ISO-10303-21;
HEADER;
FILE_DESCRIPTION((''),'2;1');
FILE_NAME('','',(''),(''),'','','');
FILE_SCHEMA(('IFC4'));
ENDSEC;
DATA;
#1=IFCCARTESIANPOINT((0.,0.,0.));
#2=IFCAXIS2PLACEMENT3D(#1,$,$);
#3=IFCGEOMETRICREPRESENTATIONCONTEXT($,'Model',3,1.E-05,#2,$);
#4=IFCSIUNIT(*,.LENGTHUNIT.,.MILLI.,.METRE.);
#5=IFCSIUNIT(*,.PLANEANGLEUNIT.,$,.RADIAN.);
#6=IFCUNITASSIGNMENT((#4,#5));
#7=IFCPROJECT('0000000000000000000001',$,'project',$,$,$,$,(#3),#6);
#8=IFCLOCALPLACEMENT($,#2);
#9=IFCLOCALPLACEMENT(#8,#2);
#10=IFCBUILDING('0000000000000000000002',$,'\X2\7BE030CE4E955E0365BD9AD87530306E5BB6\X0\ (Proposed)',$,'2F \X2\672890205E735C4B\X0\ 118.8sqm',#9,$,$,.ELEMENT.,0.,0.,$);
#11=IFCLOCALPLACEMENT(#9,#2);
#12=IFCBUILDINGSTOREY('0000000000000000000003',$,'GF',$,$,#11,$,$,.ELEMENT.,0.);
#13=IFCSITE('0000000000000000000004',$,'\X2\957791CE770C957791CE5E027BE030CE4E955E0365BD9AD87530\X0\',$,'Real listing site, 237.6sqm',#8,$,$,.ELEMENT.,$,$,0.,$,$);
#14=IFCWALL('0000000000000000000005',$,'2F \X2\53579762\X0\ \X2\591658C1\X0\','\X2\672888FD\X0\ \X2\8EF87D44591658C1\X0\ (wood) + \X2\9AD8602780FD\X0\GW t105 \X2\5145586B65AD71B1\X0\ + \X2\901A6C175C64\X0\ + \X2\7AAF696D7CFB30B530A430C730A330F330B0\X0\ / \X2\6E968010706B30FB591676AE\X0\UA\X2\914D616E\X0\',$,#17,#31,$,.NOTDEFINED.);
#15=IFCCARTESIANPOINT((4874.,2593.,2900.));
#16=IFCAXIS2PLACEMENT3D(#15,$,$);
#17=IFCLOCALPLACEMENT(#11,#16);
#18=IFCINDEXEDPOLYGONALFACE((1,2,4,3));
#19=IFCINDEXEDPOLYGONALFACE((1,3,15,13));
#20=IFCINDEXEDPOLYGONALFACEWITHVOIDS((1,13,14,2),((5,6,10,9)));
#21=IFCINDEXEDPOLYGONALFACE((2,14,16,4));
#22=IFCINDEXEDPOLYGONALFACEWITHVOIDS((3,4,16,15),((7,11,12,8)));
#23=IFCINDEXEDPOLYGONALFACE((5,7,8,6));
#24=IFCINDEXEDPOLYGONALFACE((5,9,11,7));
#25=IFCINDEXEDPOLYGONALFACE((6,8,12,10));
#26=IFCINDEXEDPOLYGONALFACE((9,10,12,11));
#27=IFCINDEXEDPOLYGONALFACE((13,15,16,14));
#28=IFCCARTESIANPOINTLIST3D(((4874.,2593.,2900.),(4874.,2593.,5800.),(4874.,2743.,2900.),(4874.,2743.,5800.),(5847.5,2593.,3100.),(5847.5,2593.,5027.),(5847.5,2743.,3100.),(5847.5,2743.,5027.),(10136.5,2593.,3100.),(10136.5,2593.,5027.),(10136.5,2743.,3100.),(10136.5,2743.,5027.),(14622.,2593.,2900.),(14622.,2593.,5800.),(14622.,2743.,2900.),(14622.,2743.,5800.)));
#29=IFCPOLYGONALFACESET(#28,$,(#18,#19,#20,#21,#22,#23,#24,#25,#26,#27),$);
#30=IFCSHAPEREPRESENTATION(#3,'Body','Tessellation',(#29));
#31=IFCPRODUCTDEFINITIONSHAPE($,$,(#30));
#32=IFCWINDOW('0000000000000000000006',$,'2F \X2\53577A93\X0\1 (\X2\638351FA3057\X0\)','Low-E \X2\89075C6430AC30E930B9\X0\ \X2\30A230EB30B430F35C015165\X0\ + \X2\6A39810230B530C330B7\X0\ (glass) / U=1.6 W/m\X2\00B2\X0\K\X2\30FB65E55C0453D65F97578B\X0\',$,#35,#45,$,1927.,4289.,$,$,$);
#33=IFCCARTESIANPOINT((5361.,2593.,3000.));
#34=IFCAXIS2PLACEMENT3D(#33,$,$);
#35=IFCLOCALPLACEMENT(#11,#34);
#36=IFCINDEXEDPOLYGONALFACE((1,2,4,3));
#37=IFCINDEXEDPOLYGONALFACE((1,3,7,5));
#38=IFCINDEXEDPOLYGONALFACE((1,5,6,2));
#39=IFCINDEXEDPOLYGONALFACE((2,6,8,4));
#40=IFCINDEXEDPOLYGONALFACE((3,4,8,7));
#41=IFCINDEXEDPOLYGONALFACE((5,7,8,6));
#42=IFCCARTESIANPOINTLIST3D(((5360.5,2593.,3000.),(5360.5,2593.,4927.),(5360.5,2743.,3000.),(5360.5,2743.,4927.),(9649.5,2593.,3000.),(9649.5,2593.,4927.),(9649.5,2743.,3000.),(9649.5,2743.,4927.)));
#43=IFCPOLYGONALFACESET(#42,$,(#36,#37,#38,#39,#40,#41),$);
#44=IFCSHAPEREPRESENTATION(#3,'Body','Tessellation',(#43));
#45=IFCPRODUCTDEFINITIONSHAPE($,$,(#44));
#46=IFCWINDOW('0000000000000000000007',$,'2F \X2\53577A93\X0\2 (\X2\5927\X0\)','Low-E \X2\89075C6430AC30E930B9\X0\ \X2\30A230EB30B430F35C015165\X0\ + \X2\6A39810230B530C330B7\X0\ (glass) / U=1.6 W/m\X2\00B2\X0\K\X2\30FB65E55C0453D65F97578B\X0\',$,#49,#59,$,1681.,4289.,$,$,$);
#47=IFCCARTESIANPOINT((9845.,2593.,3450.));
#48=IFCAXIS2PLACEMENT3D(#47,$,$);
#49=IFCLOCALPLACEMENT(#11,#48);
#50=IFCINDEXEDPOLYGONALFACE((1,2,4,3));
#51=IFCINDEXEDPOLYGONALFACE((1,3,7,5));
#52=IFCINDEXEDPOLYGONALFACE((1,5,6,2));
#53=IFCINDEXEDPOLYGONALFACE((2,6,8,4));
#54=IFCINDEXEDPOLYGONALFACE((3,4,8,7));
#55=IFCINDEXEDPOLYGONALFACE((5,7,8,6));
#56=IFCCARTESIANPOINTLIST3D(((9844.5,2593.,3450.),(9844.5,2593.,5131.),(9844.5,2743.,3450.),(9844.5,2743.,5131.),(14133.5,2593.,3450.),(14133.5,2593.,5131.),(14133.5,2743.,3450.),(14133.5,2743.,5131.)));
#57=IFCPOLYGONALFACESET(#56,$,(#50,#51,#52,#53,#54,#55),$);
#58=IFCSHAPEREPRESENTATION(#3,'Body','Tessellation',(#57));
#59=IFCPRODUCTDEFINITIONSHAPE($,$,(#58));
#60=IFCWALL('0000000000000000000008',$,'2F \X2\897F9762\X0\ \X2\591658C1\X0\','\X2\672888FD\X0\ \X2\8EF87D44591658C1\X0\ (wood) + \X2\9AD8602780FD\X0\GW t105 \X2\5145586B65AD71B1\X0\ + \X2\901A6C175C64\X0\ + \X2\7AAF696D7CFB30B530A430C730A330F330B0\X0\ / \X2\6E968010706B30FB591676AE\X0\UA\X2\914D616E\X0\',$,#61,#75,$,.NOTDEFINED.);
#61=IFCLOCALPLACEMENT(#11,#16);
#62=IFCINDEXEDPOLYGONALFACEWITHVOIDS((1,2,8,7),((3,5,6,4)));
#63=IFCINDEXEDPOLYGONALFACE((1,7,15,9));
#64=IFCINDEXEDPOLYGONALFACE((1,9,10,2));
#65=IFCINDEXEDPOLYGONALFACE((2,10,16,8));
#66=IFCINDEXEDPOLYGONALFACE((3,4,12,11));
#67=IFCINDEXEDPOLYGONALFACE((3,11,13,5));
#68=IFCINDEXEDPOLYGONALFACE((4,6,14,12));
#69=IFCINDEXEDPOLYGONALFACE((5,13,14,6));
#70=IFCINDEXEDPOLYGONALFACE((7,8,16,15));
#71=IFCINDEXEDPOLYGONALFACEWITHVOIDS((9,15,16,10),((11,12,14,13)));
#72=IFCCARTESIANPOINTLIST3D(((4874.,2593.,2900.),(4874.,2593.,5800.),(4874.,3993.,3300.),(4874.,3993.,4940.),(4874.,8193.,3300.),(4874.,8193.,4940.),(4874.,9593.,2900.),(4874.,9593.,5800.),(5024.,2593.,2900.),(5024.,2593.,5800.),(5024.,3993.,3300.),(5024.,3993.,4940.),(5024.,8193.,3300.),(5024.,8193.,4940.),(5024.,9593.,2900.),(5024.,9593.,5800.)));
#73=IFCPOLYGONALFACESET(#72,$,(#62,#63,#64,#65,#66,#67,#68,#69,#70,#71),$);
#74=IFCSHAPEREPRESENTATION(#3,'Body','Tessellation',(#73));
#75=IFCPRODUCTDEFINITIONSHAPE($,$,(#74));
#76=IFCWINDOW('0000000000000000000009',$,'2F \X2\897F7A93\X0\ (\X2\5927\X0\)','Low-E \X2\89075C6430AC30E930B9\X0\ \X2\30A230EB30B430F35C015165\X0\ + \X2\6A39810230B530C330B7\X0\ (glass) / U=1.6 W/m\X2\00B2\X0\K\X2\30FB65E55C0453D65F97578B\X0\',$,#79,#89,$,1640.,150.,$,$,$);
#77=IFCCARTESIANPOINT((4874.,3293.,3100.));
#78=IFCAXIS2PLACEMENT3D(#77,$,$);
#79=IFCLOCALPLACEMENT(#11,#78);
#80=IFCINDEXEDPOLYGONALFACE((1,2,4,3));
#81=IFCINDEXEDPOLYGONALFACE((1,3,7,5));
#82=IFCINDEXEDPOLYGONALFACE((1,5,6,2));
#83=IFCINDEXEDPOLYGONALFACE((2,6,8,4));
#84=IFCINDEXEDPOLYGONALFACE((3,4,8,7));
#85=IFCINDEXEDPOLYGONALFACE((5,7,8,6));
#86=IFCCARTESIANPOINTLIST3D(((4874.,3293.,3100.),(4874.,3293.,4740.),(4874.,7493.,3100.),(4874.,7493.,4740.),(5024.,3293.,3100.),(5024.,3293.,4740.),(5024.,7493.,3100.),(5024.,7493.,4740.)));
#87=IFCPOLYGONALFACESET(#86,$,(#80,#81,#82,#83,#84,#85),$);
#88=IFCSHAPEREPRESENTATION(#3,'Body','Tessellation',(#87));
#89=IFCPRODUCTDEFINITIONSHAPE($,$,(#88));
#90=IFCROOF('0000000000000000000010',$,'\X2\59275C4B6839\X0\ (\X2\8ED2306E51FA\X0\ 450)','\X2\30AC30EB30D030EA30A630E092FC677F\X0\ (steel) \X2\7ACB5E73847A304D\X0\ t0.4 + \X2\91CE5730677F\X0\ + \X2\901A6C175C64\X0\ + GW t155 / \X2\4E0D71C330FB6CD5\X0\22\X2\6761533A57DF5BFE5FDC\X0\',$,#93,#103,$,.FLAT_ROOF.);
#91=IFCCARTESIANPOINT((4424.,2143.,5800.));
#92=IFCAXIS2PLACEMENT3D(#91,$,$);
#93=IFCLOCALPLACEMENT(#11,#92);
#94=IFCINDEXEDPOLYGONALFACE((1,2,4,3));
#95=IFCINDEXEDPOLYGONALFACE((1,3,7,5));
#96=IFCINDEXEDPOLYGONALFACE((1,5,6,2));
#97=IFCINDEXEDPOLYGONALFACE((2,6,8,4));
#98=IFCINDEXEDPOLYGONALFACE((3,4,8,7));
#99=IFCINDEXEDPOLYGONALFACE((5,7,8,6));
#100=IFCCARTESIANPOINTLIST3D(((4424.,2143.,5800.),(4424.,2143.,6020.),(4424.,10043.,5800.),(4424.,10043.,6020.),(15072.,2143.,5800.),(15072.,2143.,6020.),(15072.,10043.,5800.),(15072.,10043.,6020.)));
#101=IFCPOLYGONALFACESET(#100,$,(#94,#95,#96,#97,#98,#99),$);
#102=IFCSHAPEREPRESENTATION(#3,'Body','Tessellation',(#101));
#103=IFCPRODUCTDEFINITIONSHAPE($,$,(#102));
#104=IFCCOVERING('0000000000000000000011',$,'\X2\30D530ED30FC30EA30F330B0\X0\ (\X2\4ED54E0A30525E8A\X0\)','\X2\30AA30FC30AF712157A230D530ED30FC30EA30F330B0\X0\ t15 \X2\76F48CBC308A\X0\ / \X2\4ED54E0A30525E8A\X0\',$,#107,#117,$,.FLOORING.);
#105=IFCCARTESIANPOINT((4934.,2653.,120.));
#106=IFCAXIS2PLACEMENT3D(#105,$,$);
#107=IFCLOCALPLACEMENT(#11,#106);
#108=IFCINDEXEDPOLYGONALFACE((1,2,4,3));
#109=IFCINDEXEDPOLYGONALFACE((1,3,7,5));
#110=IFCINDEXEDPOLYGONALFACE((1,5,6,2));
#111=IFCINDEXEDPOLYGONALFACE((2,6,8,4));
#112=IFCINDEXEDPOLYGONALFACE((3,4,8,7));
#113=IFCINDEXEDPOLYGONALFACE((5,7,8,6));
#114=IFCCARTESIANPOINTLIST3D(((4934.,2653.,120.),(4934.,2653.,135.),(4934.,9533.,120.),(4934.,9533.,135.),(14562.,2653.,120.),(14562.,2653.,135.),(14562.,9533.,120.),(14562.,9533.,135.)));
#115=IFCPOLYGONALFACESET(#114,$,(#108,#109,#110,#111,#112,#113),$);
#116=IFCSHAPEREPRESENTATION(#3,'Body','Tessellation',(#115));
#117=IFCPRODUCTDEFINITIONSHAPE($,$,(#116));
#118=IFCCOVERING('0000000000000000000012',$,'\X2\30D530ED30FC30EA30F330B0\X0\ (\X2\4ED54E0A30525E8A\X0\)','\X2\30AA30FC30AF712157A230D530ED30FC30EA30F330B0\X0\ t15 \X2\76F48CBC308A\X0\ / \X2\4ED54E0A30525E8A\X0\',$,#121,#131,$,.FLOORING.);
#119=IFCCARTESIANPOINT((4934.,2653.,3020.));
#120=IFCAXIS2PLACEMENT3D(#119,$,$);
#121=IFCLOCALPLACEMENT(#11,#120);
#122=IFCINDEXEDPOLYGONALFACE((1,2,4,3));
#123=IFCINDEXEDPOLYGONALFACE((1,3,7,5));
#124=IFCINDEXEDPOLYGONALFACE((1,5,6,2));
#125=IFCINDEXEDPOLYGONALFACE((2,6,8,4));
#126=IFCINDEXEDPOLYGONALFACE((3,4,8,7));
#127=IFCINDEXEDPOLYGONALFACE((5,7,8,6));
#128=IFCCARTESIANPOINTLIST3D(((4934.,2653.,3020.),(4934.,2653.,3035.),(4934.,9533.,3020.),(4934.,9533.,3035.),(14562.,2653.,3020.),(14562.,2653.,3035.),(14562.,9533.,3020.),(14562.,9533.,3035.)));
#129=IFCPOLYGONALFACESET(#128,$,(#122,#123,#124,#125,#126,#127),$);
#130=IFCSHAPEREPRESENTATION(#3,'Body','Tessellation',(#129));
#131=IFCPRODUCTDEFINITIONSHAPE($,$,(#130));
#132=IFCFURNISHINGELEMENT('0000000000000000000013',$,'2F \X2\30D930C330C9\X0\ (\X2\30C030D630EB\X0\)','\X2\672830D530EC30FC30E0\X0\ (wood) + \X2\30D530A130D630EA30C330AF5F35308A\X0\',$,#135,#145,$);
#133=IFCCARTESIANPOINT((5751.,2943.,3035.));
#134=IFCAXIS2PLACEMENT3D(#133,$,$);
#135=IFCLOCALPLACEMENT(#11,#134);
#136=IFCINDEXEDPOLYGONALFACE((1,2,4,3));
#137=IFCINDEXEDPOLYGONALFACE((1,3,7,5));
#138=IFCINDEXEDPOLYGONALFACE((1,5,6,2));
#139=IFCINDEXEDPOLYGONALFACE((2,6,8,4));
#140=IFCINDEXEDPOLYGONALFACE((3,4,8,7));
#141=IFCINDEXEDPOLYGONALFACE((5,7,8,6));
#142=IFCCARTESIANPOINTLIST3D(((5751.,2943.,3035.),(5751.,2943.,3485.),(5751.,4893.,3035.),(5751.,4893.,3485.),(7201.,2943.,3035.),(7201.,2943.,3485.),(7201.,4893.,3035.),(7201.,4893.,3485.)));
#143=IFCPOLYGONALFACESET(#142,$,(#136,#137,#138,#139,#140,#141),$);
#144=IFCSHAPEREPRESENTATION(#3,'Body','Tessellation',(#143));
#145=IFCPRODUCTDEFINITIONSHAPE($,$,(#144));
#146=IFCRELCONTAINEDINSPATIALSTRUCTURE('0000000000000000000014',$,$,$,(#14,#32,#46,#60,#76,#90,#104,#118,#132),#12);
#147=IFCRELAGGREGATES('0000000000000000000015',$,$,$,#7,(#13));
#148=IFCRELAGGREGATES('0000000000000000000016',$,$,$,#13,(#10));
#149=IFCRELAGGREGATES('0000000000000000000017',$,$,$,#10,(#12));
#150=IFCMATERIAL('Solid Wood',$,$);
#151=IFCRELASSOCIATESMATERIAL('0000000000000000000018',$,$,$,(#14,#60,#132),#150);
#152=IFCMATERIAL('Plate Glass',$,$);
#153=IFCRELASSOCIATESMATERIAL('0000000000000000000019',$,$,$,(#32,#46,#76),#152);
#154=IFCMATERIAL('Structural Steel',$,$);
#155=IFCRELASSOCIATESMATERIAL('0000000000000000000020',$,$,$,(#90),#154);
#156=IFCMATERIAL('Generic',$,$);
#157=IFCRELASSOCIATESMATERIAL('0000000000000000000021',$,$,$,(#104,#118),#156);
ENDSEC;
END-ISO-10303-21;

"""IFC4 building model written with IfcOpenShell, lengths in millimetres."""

from ifc_helpers import new_model, si_unit, frame, frame_2d, origin, place, context, project, spatial, rectangle, extrude, material, element, fill, save


model = new_model("IFC4")

# Units and contexts
model_context = context("Model", 3, precision=1e-05, world=origin())
ifc_project = project(units=[si_unit("LENGTHUNIT", "METRE", prefix="MILLI"), si_unit("PLANEANGLEUNIT", "RADIAN")], contexts=[model_context])

# Site, building, storey
site_placement = place(None, origin())
site = spatial("IfcSite", under=ifc_project, at=site_placement, Name="長野県長野市篠ノ井布施高田", ObjectType="Real listing site, 237.6sqm", CompositionType="ELEMENT", RefElevation=0.0)
building_placement = place(site_placement, origin())
building = spatial("IfcBuilding", under=site, at=building_placement, Name="篠ノ井布施高田の家 (Proposed)", ObjectType="2F 木造平屋 118.8sqm", CompositionType="ELEMENT", ElevationOfRefHeight=0.0, ElevationOfTerrain=0.0)
storey_placement = place(building_placement, origin())
storey = spatial("IfcBuildingStorey", under=building, at=storey_placement, Name="GF", CompositionType="ELEMENT", Elevation=0.0)

# Shared definitions
ifc_material_1 = material(Name="Solid Wood")

# Shared definitions
ifc_material_2 = material(Name="Plate Glass")

# Wall, openings, windows
wall_1_placement = place(storey_placement, frame((4874.0, 2593.0, 2900.0)))
wall_1 = element("IfcWall", 1, at=wall_1_placement, inside=storey, material=ifc_material_1, Name="2F 南面 外壁", Description="木製 軸組外壁 (wood) + 高性能GW t105 充填断熱 + 通気層 + 窯業系サイディング / 準耐火・外皮UA配慮", PredefinedType="NOTDEFINED", context=model_context, shape_type="SweptSolid", body=[
    extrude(rectangle(XDim=9748.0, YDim=150.0, at=frame_2d((4874.0, 75.0))), frame((4874.0, 2593.0, 2900.0)), (0.0, 0.0, 1.0), 2900.0),
])
opening_1_placement = place(storey_placement, frame((5361.0, 2593.0, 3000.0)))
opening_1 = element("IfcOpeningElement", 2, at=opening_1_placement, cuts=wall_1, PredefinedType="NOTDEFINED", context=model_context, shape_type="SweptSolid", body=[
    extrude(rectangle(XDim=4289.0, YDim=150.0, at=frame_2d((2144.0, 75.0))), frame((5361.0, 2593.0, 3000.0)), (0.0, 0.0, 1.0), 1927.0),
])
opening_2_placement = place(storey_placement, frame((9845.0, 2593.0, 3450.0)))
opening_2 = element("IfcOpeningElement", 3, at=opening_2_placement, cuts=wall_1, PredefinedType="NOTDEFINED", context=model_context, shape_type="SweptSolid", body=[
    extrude(rectangle(XDim=4289.0, YDim=150.0, at=frame_2d((2144.0, 75.0))), frame((9845.0, 2593.0, 3450.0)), (0.0, 0.0, 1.0), 1681.0),
])
window_1_placement = place(storey_placement, frame((5361.0, 2593.0, 3000.0)))
window_1 = element("IfcWindow", 4, at=window_1_placement, inside=storey, material=ifc_material_2, Name="2F 南窓1 (掃出し)", Description="Low-E 複層ガラス アルゴン封入 + 樹脂サッシ (glass) / U=1.6 W/m²K・日射取得型", OverallHeight=1927.0, OverallWidth=4289.0, context=model_context, shape_type="SweptSolid", body=[
    extrude(rectangle(XDim=4289.0, YDim=150.0, at=frame_2d((2144.0, 75.0))), frame((5361.0, 2593.0, 3000.0)), (0.0, 0.0, 1.0), 1927.0),
])
fill(opening_1, window_1)
window_2_placement = place(storey_placement, frame((9845.0, 2593.0, 3450.0)))
window_2 = element("IfcWindow", 5, at=window_2_placement, inside=storey, material=ifc_material_2, Name="2F 南窓2 (大)", Description="Low-E 複層ガラス アルゴン封入 + 樹脂サッシ (glass) / U=1.6 W/m²K・日射取得型", OverallHeight=1681.0, OverallWidth=4289.0, context=model_context, shape_type="SweptSolid", body=[
    extrude(rectangle(XDim=4289.0, YDim=150.0, at=frame_2d((2144.0, 75.0))), frame((9845.0, 2593.0, 3450.0)), (0.0, 0.0, 1.0), 1681.0),
])
fill(opening_2, window_2)

# Wall, opening, window
wall_2_placement = place(storey_placement, frame((4874.0, 2593.0, 2900.0)))
wall_2 = element("IfcWall", 6, at=wall_2_placement, inside=storey, material=ifc_material_1, Name="2F 西面 外壁", Description="木製 軸組外壁 (wood) + 高性能GW t105 充填断熱 + 通気層 + 窯業系サイディング / 準耐火・外皮UA配慮", PredefinedType="NOTDEFINED", context=model_context, shape_type="SweptSolid", body=[
    extrude(rectangle(XDim=150.0, YDim=7000.0, at=frame_2d((75.0, 3500.0))), frame((4874.0, 2593.0, 2900.0)), (0.0, 0.0, 1.0), 2900.0),
])
opening_3_placement = place(storey_placement, frame((4874.0, 3293.0, 3100.0)))
opening_3 = element("IfcOpeningElement", 7, at=opening_3_placement, cuts=wall_2, PredefinedType="NOTDEFINED", context=model_context, shape_type="SweptSolid", body=[
    extrude(rectangle(XDim=150.0, YDim=4200.0, at=frame_2d((75.0, 2100.0))), frame((4874.0, 3293.0, 3100.0)), (0.0, 0.0, 1.0), 1640.0),
])
window_3_placement = place(storey_placement, frame((4874.0, 3293.0, 3100.0)))
window_3 = element("IfcWindow", 8, at=window_3_placement, inside=storey, material=ifc_material_2, Name="2F 西窓 (大)", Description="Low-E 複層ガラス アルゴン封入 + 樹脂サッシ (glass) / U=1.6 W/m²K・日射取得型", OverallHeight=1640.0, OverallWidth=150.0, context=model_context, shape_type="SweptSolid", body=[
    extrude(rectangle(XDim=150.0, YDim=4200.0, at=frame_2d((75.0, 2100.0))), frame((4874.0, 3293.0, 3100.0)), (0.0, 0.0, 1.0), 1640.0),
])
fill(opening_3, window_3)

# Roof
ifc_material_3 = material(Name="Structural Steel")
roof_placement = place(storey_placement, frame((4424.0, 2143.0, 5800.0)))
element("IfcRoof", 9, at=roof_placement, inside=storey, material=ifc_material_3, Name="大屋根 (軒の出 450)", Description="ガルバリウム鋼板 (steel) 立平葺き t0.4 + 野地板 + 通気層 + GW t155 / 不燃・法22条区域対応", PredefinedType="FLAT_ROOF", context=model_context, shape_type="SweptSolid", body=[
    extrude(rectangle(XDim=10648.0, YDim=7900.0, at=frame_2d((5324.0, 3950.0))), frame((4424.0, 2143.0, 5800.0)), (0.0, 0.0, 1.0), 220.0),
])

# Coverings
ifc_material_4 = material(Name="Generic")
covering_1_placement = place(storey_placement, frame((4934.0, 2653.0, 120.0)))
element("IfcCovering", 10, at=covering_1_placement, inside=storey, material=ifc_material_4, Name="フローリング (仕上げ床)", Description="オーク無垢フローリング t15 直貼り / 仕上げ床", PredefinedType="FLOORING", context=model_context, shape_type="SweptSolid", body=[
    extrude(rectangle(XDim=9628.0, YDim=6880.0, at=frame_2d((4814.0, 3440.0))), frame((4934.0, 2653.0, 120.0)), (0.0, 0.0, 1.0), 15.0),
])
covering_2_placement = place(storey_placement, frame((4934.0, 2653.0, 3020.0)))
element("IfcCovering", 11, at=covering_2_placement, inside=storey, material=ifc_material_4, Name="フローリング (仕上げ床)", Description="オーク無垢フローリング t15 直貼り / 仕上げ床", PredefinedType="FLOORING", context=model_context, shape_type="SweptSolid", body=[
    extrude(rectangle(XDim=9628.0, YDim=6880.0, at=frame_2d((4814.0, 3440.0))), frame((4934.0, 2653.0, 3020.0)), (0.0, 0.0, 1.0), 15.0),
])

# Furnishing element
furnishing_placement = place(storey_placement, frame((5751.0, 2943.0, 3035.0)))
element("IfcFurnishingElement", 12, at=furnishing_placement, inside=storey, material=ifc_material_1, Name="2F ベッド (ダブル)", Description="木フレーム (wood) + ファブリック張り", context=model_context, shape_type="SweptSolid", body=[
    extrude(rectangle(XDim=1450.0, YDim=1950.0, at=frame_2d((725.0, 975.0))), frame((5751.0, 2943.0, 3035.0)), (0.0, 0.0, 1.0), 450.0),
])

save(model, "model.ifc")
